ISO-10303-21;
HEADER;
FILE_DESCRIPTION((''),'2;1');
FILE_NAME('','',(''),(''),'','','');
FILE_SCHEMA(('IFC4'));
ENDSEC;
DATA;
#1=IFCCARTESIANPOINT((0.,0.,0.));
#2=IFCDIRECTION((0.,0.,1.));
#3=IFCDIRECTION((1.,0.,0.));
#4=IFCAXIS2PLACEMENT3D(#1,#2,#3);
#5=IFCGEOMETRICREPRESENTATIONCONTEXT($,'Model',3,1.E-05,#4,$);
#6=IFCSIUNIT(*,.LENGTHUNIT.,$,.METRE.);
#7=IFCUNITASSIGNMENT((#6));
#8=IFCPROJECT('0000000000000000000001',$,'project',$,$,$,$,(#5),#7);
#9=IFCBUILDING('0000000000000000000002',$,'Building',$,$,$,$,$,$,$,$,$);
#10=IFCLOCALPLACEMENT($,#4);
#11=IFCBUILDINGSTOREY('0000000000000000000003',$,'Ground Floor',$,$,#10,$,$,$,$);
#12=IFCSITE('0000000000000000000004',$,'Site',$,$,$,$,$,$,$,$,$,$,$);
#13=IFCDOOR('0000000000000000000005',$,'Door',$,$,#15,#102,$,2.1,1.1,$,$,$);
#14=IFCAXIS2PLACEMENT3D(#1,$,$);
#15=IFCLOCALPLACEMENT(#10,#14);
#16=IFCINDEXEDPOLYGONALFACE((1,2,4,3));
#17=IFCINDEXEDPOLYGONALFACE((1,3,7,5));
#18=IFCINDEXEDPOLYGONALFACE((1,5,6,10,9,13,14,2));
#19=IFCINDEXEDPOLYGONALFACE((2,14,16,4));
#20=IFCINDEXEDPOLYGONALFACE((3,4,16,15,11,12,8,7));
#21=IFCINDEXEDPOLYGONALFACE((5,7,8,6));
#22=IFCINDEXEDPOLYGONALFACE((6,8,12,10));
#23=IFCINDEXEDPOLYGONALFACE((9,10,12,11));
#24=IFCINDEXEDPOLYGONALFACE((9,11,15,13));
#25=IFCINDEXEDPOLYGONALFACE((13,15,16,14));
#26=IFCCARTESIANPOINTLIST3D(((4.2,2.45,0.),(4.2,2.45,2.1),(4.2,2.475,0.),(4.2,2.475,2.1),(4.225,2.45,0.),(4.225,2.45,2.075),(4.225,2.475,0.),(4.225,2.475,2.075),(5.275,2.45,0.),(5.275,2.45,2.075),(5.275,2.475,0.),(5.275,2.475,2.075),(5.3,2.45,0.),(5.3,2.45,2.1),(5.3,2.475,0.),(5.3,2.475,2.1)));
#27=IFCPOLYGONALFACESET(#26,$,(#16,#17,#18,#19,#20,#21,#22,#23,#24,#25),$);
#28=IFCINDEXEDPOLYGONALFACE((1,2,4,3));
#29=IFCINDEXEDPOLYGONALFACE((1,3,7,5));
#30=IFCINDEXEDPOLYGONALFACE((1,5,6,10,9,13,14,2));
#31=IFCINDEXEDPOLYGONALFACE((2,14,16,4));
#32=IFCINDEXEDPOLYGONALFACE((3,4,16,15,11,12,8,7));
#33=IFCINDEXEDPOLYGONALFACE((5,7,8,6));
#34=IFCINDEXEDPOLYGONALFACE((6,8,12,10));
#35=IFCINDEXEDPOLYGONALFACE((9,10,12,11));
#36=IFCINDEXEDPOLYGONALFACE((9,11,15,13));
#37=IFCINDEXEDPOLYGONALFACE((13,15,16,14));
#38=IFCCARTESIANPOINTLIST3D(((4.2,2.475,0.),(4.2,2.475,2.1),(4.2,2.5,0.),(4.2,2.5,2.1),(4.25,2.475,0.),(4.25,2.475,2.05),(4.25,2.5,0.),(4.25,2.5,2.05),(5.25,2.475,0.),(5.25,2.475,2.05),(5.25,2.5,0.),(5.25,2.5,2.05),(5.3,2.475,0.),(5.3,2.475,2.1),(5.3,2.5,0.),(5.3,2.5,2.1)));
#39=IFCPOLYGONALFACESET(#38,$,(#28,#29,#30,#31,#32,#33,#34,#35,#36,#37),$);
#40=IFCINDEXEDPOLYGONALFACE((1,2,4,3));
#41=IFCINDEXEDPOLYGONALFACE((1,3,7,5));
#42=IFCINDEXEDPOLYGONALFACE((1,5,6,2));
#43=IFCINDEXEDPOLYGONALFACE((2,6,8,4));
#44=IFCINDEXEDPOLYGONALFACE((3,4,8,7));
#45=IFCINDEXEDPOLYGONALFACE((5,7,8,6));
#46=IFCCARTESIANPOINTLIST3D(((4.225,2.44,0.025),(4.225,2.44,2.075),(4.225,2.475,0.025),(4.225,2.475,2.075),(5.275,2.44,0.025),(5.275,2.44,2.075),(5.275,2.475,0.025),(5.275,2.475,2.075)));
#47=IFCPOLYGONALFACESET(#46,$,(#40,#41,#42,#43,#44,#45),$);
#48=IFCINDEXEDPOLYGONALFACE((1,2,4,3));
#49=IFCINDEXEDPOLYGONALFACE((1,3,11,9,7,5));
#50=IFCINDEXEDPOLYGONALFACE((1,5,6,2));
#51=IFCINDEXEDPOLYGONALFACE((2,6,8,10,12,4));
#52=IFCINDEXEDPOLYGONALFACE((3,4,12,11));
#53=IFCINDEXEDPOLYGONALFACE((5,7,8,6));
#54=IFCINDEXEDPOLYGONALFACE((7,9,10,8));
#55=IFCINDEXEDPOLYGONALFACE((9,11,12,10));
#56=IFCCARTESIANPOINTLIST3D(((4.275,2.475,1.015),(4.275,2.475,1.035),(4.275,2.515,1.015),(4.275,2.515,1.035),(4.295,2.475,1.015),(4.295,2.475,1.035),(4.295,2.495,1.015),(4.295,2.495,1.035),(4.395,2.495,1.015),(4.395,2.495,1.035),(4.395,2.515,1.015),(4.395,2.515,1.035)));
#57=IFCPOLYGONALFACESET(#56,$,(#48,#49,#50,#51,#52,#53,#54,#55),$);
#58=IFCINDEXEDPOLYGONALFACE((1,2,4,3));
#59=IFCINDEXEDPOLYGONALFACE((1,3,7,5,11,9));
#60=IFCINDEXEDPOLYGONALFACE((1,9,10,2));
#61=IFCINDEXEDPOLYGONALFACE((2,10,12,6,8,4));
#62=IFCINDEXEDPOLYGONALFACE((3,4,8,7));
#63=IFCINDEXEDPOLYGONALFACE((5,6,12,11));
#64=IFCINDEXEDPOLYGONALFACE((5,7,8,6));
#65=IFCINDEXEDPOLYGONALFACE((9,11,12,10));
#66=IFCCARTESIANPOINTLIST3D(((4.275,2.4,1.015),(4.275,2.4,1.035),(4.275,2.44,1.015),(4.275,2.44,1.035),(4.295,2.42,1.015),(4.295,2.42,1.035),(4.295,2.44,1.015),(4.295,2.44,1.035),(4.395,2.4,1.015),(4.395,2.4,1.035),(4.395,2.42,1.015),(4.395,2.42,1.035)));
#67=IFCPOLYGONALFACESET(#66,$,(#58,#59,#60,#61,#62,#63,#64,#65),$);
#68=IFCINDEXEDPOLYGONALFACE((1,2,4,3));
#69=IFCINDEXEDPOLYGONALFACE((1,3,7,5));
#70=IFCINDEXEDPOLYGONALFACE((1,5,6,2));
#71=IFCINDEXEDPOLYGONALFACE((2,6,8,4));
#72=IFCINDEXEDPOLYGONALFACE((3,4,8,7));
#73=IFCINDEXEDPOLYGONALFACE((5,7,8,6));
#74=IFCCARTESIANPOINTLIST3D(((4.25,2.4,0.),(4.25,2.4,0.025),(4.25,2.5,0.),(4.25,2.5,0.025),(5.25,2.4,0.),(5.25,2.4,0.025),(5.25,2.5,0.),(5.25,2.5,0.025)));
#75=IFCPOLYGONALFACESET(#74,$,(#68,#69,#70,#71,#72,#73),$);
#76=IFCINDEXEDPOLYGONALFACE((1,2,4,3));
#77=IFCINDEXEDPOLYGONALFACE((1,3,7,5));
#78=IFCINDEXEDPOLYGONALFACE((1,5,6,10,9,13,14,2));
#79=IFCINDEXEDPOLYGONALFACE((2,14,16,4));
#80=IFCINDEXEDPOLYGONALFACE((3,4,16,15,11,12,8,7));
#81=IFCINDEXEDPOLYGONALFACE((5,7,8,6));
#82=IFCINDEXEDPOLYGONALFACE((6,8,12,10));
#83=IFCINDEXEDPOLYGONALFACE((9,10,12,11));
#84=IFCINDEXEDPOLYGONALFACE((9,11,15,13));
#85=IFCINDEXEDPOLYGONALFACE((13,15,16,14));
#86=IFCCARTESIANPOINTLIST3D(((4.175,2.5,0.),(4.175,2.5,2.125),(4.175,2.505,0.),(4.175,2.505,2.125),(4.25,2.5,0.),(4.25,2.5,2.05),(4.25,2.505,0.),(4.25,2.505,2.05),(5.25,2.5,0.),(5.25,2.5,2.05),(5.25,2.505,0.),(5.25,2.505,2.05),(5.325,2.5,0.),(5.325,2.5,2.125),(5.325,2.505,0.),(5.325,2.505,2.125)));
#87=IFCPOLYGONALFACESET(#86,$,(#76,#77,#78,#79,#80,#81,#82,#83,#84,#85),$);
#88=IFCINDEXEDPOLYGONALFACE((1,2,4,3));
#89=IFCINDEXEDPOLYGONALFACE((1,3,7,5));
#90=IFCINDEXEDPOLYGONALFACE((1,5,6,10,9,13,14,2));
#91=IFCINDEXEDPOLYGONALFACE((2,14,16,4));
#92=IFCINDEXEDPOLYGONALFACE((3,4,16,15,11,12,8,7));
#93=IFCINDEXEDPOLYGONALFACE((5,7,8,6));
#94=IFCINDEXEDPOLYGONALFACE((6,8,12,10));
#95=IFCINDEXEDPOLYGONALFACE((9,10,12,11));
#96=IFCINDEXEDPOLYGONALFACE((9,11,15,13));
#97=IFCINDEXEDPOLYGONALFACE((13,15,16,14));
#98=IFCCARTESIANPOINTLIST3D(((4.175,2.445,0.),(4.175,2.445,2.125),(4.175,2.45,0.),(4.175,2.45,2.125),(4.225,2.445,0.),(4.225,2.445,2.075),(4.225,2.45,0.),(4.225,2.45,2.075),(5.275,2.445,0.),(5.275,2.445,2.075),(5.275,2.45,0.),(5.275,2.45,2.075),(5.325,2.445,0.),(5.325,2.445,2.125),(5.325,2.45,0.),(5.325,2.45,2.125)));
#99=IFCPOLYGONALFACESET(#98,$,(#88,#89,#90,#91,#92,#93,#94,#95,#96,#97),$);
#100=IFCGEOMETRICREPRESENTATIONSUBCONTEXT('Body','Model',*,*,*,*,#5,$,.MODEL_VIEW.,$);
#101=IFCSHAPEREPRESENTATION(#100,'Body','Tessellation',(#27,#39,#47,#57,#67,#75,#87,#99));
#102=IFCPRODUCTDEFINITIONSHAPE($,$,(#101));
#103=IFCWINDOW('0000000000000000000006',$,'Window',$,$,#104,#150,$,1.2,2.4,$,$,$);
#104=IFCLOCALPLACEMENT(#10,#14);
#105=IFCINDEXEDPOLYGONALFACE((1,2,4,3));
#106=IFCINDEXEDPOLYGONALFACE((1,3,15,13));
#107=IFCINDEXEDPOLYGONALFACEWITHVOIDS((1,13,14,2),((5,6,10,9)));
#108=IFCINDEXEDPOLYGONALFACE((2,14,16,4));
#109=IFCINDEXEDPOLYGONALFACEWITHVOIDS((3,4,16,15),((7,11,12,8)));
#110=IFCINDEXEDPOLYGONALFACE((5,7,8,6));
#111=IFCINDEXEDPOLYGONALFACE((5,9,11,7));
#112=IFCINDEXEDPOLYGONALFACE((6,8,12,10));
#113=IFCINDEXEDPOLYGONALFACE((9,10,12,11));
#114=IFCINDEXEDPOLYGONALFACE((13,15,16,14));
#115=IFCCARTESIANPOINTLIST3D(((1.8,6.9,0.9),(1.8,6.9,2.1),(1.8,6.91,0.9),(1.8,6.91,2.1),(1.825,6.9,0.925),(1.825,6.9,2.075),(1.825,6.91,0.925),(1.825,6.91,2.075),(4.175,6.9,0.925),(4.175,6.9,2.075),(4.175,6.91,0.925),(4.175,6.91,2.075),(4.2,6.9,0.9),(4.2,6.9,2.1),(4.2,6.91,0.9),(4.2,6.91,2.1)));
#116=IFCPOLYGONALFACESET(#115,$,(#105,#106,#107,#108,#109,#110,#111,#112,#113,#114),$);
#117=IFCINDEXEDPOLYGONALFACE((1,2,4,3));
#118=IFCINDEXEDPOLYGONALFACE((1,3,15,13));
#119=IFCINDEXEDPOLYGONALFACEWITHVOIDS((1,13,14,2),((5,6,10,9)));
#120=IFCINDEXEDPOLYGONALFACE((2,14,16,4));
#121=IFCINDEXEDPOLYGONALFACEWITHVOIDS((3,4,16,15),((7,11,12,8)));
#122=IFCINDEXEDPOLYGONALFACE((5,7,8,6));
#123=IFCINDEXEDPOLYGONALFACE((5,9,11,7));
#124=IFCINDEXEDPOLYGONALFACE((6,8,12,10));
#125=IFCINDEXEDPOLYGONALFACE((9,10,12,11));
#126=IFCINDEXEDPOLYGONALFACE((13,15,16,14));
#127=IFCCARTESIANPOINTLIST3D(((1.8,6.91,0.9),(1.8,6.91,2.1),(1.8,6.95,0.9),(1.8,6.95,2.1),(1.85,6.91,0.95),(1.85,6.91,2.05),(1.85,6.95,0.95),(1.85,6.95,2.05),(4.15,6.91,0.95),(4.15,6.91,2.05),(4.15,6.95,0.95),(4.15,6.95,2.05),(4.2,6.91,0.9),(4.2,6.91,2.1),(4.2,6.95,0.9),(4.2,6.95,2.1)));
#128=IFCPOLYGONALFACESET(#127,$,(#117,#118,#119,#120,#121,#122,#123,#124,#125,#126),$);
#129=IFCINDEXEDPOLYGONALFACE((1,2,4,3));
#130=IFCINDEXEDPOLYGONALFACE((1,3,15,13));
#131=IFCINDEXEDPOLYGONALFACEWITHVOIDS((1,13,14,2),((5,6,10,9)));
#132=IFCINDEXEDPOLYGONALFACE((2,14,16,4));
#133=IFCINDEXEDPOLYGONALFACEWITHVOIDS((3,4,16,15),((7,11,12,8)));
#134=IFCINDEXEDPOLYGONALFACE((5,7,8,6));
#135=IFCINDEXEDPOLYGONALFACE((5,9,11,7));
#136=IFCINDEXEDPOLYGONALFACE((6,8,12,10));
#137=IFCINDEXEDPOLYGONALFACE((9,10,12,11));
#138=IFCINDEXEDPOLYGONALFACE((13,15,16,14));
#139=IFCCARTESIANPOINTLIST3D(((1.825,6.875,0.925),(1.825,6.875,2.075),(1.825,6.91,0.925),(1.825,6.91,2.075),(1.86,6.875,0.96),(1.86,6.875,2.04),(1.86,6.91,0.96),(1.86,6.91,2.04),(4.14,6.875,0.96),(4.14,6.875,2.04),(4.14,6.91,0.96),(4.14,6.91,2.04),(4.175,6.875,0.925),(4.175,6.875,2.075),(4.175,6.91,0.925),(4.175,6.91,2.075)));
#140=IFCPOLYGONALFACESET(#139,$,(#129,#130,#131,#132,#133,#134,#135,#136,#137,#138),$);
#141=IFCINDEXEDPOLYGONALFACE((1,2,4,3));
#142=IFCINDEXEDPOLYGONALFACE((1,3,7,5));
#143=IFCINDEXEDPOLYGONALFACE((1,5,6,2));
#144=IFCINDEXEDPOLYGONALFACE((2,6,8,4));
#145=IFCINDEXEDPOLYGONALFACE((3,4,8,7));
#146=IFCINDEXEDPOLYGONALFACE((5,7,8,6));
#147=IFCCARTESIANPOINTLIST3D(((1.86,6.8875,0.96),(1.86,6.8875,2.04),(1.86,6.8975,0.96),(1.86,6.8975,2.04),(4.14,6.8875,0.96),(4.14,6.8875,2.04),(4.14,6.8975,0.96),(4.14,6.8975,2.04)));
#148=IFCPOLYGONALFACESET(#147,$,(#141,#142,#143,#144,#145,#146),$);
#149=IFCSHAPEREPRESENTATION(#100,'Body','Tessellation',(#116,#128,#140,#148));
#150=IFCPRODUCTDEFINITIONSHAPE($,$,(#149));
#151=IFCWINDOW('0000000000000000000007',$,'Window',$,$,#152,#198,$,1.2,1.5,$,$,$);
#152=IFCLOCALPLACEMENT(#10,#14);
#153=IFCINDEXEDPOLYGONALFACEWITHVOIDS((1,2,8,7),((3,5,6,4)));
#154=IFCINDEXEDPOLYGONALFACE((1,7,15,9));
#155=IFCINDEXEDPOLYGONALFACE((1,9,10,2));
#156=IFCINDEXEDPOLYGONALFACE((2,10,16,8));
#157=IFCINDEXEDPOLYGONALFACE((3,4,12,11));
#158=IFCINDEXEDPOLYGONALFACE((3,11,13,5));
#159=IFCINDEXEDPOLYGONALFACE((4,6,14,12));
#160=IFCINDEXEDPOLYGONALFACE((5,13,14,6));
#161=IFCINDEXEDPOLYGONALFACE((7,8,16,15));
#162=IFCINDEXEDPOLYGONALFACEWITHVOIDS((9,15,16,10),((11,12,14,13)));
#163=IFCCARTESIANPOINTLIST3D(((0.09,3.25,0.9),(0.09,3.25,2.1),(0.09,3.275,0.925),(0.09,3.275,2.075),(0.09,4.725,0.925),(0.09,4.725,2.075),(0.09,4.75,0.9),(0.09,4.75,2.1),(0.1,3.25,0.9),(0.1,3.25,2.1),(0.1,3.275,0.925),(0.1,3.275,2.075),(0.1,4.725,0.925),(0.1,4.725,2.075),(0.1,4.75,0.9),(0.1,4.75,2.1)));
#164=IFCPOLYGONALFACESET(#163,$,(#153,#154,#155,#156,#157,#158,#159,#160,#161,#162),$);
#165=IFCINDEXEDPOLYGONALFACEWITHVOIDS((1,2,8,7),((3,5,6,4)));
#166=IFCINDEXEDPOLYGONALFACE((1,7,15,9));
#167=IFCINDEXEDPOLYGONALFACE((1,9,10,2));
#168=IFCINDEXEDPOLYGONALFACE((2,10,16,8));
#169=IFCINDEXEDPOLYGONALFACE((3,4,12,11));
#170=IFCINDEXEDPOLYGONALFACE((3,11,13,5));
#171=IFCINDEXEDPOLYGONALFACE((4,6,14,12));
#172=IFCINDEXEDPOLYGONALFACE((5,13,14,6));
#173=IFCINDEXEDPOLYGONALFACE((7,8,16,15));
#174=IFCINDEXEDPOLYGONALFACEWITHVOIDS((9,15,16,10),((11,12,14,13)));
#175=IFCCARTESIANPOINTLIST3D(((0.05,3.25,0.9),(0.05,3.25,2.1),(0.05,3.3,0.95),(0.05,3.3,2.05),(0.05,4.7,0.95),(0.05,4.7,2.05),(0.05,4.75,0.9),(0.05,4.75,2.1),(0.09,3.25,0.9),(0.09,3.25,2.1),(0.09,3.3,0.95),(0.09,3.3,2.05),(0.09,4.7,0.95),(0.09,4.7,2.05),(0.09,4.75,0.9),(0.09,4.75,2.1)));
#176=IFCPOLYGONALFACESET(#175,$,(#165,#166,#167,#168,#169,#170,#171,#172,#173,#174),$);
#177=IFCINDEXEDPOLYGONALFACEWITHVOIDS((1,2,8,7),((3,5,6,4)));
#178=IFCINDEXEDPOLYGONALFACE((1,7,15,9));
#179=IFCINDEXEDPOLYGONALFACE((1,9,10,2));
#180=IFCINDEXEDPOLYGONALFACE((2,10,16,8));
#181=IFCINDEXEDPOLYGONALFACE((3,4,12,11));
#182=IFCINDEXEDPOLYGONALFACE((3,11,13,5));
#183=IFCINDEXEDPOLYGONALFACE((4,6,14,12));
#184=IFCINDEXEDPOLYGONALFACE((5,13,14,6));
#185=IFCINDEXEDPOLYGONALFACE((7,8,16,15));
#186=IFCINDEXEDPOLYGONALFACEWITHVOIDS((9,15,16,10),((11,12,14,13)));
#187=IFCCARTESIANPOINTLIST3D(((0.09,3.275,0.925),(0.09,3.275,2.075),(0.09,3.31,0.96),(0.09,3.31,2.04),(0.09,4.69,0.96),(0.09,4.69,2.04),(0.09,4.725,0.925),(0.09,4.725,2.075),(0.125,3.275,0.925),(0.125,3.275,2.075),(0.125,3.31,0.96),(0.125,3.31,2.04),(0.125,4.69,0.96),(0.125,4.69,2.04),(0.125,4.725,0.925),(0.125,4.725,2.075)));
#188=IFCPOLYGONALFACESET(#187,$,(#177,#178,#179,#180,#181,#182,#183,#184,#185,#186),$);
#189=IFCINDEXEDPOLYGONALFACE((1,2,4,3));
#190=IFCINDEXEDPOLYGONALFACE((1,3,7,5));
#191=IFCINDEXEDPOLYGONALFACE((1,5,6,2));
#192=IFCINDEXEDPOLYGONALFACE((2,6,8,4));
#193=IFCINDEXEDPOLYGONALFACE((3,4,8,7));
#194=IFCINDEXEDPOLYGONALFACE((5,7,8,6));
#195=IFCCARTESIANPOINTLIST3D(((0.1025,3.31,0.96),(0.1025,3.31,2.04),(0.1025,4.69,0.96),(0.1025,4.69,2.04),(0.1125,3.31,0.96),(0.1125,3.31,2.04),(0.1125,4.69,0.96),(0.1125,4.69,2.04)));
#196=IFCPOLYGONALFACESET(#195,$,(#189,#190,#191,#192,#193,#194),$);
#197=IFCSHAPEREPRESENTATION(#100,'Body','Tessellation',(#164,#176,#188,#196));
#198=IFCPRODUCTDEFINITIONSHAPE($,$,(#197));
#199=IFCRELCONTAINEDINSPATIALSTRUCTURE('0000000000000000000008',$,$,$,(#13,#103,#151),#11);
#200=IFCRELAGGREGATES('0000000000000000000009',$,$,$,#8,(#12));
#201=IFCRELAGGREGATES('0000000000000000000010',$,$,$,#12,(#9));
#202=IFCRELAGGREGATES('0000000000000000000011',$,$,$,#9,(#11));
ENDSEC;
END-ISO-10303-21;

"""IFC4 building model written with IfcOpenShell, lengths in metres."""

from ifc_helpers import new_model, si_unit, frame, origin_with_axes, place, context, subcontext, project, spatial, line, indexed_curve, outline, extrude, element, save


model = new_model("IFC4")

# Units and contexts
model_context = context("Model", 3, precision=1e-05, world=origin_with_axes())
body_context = subcontext(model_context, "Body", "Model", "MODEL_VIEW")
ifc_project = project(units=[si_unit("LENGTHUNIT", "METRE")], contexts=[model_context])

# Site, building, storey
site = spatial("IfcSite", under=ifc_project, Name="Site")
building = spatial("IfcBuilding", under=site, Name="Building")
storey_placement = place(None, origin_with_axes())
storey = spatial("IfcBuildingStorey", under=building, at=storey_placement, Name="Ground Floor")

# Door
door_1_placement = place(storey_placement, frame((5.3, 2.5, 0.0), z_axis=(0.0, 0.0, 1.0), x_axis=(-1.0, 0.0, 0.0)))
element("IfcDoor", 1, at=door_1_placement, inside=storey, Name="Door", OverallHeight=2.1, OverallWidth=1.1, context=body_context, shape_type="SweptSolid", body=[
    extrude(outline(indexed_curve([(0.0, 0.0), (0.0, 2.1), (1.1, 2.1), (1.1, 0.0), (1.075, 0.0), (1.075, 2.075), (0.025, 2.075), (0.025, 0.0)], segments=[line(1, 2, 3, 4, 5, 6, 7, 8, 1)])), frame((0.0, 0.025, 0.0), z_axis=(0.0, -1.0, 0.0), x_axis=(1.0, 0.0, 0.0)), (0.0, 0.0, -1.0), 0.025),
    extrude(outline(indexed_curve([(0.0, 0.0), (0.0, 2.1), (1.1, 2.1), (1.1, 0.0), (1.05, 0.0), (1.05, 2.05), (0.05, 2.05), (0.05, 0.0)], segments=[line(1, 2, 3, 4, 5, 6, 7, 8, 1)])), frame((0.0, 0.0, 0.0), z_axis=(0.0, -1.0, 0.0), x_axis=(1.0, 0.0, 0.0)), (0.0, 0.0, -1.0), 0.025),
    extrude(outline(indexed_curve([(0.0, 0.0), (1.05, 0.0), (1.05, 0.035), (0.0, 0.035)], segments=[line(1, 2, 3, 4, 1)])), frame((0.025, 0.025, 0.025), z_axis=(0.0, 0.0, 1.0), x_axis=(1.0, 0.0, 0.0)), (0.0, 0.0, 1.0), 2.05),
    extrude(outline(indexed_curve([(0.0, 0.0), (0.0, -0.04), (-0.12, -0.04), (-0.12, -0.02), (-0.02, -0.02), (-0.02, 0.0)], segments=[line(1, 2, 3, 4, 5, 6, 1)])), frame((1.025, 0.025, 1.015), z_axis=(0.0, 0.0, 1.0), x_axis=(1.0, 0.0, 0.0)), (0.0, 0.0, 1.0), 0.02),
    extrude(outline(indexed_curve([(0.0, 0.0), (0.0, 0.04), (-0.12, 0.04), (-0.12, 0.02), (-0.02, 0.02), (-0.02, 0.0)], segments=[line(1, 2, 3, 4, 5, 6, 1)])), frame((1.025, 0.06, 1.015), z_axis=(0.0, 0.0, 1.0), x_axis=(1.0, 0.0, 0.0)), (0.0, 0.0, 1.0), 0.02),
    extrude(outline(indexed_curve([(0.0, 0.0), (1.0, 0.0), (1.0, 0.1), (0.0, 0.1)], segments=[line(1, 2, 3, 4, 1)])), frame((0.05, 0.0, 0.0), z_axis=(0.0, 0.0, 1.0), x_axis=(1.0, 0.0, 0.0)), (0.0, 0.0, 1.0), 0.025),
    extrude(outline(indexed_curve([(0.0, 0.0), (0.0, 2.125), (1.15, 2.125), (1.15, 0.0), (1.075, 0.0), (1.075, 2.05), (0.075, 2.05), (0.075, 0.0)], segments=[line(1, 2, 3, 4, 5, 6, 7, 8, 1)])), frame((-0.025, -0.005, 0.0), z_axis=(0.0, -1.0, 0.0), x_axis=(1.0, 0.0, 0.0)), (0.0, 0.0, -1.0), 0.005),
    extrude(outline(indexed_curve([(0.0, 0.0), (0.0, 2.125), (1.15, 2.125), (1.15, 0.0), (1.1, 0.0), (1.1, 2.075), (0.05, 2.075), (0.05, 0.0)], segments=[line(1, 2, 3, 4, 5, 6, 7, 8, 1)])), frame((-0.025, 0.05, 0.0), z_axis=(0.0, -1.0, 0.0), x_axis=(1.0, 0.0, 0.0)), (0.0, 0.0, -1.0), 0.005),
])

# Windows
window_1_placement = place(storey_placement, frame((4.2, 7.0, 0.9), z_axis=(0.0, 0.0, 1.0), x_axis=(-1.0, 0.0, 0.0)))
element("IfcWindow", 2, at=window_1_placement, inside=storey, Name="Window", OverallHeight=1.2, OverallWidth=2.4, context=body_context, shape_type="SweptSolid", body=[
    extrude(outline(indexed_curve([(0.0, 0.0), (2.4, 0.0), (2.4, 1.2), (0.0, 1.2)], segments=[line(1, 2, 3, 4, 1)]), holes=[indexed_curve([(0.025, 0.025), (2.375, 0.025), (2.375, 1.175), (0.025, 1.175)], segments=[line(1, 2, 3, 4, 1)])]), frame((0.0, 0.09, 0.0), z_axis=(0.0, -1.0, 0.0), x_axis=(1.0, 0.0, 0.0)), (0.0, 0.0, -1.0), 0.01),
    extrude(outline(indexed_curve([(0.0, 0.0), (2.4, 0.0), (2.4, 1.2), (0.0, 1.2)], segments=[line(1, 2, 3, 4, 1)]), holes=[indexed_curve([(0.05, 0.05), (2.35, 0.05), (2.35, 1.15), (0.05, 1.15)], segments=[line(1, 2, 3, 4, 1)])]), frame((0.0, 0.05, 0.0), z_axis=(0.0, -1.0, 0.0), x_axis=(1.0, 0.0, 0.0)), (0.0, 0.0, -1.0), 0.04),
    extrude(outline(indexed_curve([(0.0, 0.0), (2.35, 0.0), (2.35, 1.15), (0.0, 1.15)], segments=[line(1, 2, 3, 4, 1)]), holes=[indexed_curve([(0.035, 0.035), (2.315, 0.035), (2.315, 1.115), (0.035, 1.115)], segments=[line(1, 2, 3, 4, 1)])]), frame((0.025, 0.09, 0.025), z_axis=(0.0, -1.0, 0.0), x_axis=(1.0, 0.0, 0.0)), (0.0, 0.0, -1.0), 0.035),
    extrude(outline(indexed_curve([(0.035, 0.035), (2.315, 0.035), (2.315, 1.115), (0.035, 1.115)], segments=[line(1, 2, 3, 4, 1)])), frame((0.025, 0.1025, 0.025), z_axis=(0.0, -1.0, 0.0), x_axis=(1.0, 0.0, 0.0)), (0.0, 0.0, -1.0), 0.01),
])
for number, where, z_axis, x_axis, name in (
    (3, (0.0, 4.75, 0.9), (0.0, 0.0, 1.0), (0.0, -1.0, 0.0), "Window"),
):
    element("IfcWindow", number, at=place(storey_placement, frame(where, z_axis=z_axis, x_axis=x_axis)), inside=storey, Name=name, OverallHeight=1.2, OverallWidth=1.5, context=body_context, shape_type="SweptSolid", body=[
        extrude(outline(indexed_curve([(0.0, 0.0), (1.5, 0.0), (1.5, 1.2), (0.0, 1.2)], segments=[line(1, 2, 3, 4, 1)]), holes=[indexed_curve([(0.025, 0.025), (1.475, 0.025), (1.475, 1.175), (0.025, 1.175)], segments=[line(1, 2, 3, 4, 1)])]), frame((0.0, 0.09, 0.0), z_axis=(0.0, -1.0, 0.0), x_axis=(1.0, 0.0, 0.0)), (0.0, 0.0, -1.0), 0.01),
        extrude(outline(indexed_curve([(0.0, 0.0), (1.5, 0.0), (1.5, 1.2), (0.0, 1.2)], segments=[line(1, 2, 3, 4, 1)]), holes=[indexed_curve([(0.05, 0.05), (1.45, 0.05), (1.45, 1.15), (0.05, 1.15)], segments=[line(1, 2, 3, 4, 1)])]), frame((0.0, 0.05, 0.0), z_axis=(0.0, -1.0, 0.0), x_axis=(1.0, 0.0, 0.0)), (0.0, 0.0, -1.0), 0.04),
        extrude(outline(indexed_curve([(0.0, 0.0), (1.45, 0.0), (1.45, 1.15), (0.0, 1.15)], segments=[line(1, 2, 3, 4, 1)]), holes=[indexed_curve([(0.035, 0.035), (1.415, 0.035), (1.415, 1.115), (0.035, 1.115)], segments=[line(1, 2, 3, 4, 1)])]), frame((0.025, 0.09, 0.025), z_axis=(0.0, -1.0, 0.0), x_axis=(1.0, 0.0, 0.0)), (0.0, 0.0, -1.0), 0.035),
        extrude(outline(indexed_curve([(0.035, 0.035), (1.415, 0.035), (1.415, 1.115), (0.035, 1.115)], segments=[line(1, 2, 3, 4, 1)])), frame((0.025, 0.1025, 0.025), z_axis=(0.0, -1.0, 0.0), x_axis=(1.0, 0.0, 0.0)), (0.0, 0.0, -1.0), 0.01),
    ])

save(model, "model.ifc")
